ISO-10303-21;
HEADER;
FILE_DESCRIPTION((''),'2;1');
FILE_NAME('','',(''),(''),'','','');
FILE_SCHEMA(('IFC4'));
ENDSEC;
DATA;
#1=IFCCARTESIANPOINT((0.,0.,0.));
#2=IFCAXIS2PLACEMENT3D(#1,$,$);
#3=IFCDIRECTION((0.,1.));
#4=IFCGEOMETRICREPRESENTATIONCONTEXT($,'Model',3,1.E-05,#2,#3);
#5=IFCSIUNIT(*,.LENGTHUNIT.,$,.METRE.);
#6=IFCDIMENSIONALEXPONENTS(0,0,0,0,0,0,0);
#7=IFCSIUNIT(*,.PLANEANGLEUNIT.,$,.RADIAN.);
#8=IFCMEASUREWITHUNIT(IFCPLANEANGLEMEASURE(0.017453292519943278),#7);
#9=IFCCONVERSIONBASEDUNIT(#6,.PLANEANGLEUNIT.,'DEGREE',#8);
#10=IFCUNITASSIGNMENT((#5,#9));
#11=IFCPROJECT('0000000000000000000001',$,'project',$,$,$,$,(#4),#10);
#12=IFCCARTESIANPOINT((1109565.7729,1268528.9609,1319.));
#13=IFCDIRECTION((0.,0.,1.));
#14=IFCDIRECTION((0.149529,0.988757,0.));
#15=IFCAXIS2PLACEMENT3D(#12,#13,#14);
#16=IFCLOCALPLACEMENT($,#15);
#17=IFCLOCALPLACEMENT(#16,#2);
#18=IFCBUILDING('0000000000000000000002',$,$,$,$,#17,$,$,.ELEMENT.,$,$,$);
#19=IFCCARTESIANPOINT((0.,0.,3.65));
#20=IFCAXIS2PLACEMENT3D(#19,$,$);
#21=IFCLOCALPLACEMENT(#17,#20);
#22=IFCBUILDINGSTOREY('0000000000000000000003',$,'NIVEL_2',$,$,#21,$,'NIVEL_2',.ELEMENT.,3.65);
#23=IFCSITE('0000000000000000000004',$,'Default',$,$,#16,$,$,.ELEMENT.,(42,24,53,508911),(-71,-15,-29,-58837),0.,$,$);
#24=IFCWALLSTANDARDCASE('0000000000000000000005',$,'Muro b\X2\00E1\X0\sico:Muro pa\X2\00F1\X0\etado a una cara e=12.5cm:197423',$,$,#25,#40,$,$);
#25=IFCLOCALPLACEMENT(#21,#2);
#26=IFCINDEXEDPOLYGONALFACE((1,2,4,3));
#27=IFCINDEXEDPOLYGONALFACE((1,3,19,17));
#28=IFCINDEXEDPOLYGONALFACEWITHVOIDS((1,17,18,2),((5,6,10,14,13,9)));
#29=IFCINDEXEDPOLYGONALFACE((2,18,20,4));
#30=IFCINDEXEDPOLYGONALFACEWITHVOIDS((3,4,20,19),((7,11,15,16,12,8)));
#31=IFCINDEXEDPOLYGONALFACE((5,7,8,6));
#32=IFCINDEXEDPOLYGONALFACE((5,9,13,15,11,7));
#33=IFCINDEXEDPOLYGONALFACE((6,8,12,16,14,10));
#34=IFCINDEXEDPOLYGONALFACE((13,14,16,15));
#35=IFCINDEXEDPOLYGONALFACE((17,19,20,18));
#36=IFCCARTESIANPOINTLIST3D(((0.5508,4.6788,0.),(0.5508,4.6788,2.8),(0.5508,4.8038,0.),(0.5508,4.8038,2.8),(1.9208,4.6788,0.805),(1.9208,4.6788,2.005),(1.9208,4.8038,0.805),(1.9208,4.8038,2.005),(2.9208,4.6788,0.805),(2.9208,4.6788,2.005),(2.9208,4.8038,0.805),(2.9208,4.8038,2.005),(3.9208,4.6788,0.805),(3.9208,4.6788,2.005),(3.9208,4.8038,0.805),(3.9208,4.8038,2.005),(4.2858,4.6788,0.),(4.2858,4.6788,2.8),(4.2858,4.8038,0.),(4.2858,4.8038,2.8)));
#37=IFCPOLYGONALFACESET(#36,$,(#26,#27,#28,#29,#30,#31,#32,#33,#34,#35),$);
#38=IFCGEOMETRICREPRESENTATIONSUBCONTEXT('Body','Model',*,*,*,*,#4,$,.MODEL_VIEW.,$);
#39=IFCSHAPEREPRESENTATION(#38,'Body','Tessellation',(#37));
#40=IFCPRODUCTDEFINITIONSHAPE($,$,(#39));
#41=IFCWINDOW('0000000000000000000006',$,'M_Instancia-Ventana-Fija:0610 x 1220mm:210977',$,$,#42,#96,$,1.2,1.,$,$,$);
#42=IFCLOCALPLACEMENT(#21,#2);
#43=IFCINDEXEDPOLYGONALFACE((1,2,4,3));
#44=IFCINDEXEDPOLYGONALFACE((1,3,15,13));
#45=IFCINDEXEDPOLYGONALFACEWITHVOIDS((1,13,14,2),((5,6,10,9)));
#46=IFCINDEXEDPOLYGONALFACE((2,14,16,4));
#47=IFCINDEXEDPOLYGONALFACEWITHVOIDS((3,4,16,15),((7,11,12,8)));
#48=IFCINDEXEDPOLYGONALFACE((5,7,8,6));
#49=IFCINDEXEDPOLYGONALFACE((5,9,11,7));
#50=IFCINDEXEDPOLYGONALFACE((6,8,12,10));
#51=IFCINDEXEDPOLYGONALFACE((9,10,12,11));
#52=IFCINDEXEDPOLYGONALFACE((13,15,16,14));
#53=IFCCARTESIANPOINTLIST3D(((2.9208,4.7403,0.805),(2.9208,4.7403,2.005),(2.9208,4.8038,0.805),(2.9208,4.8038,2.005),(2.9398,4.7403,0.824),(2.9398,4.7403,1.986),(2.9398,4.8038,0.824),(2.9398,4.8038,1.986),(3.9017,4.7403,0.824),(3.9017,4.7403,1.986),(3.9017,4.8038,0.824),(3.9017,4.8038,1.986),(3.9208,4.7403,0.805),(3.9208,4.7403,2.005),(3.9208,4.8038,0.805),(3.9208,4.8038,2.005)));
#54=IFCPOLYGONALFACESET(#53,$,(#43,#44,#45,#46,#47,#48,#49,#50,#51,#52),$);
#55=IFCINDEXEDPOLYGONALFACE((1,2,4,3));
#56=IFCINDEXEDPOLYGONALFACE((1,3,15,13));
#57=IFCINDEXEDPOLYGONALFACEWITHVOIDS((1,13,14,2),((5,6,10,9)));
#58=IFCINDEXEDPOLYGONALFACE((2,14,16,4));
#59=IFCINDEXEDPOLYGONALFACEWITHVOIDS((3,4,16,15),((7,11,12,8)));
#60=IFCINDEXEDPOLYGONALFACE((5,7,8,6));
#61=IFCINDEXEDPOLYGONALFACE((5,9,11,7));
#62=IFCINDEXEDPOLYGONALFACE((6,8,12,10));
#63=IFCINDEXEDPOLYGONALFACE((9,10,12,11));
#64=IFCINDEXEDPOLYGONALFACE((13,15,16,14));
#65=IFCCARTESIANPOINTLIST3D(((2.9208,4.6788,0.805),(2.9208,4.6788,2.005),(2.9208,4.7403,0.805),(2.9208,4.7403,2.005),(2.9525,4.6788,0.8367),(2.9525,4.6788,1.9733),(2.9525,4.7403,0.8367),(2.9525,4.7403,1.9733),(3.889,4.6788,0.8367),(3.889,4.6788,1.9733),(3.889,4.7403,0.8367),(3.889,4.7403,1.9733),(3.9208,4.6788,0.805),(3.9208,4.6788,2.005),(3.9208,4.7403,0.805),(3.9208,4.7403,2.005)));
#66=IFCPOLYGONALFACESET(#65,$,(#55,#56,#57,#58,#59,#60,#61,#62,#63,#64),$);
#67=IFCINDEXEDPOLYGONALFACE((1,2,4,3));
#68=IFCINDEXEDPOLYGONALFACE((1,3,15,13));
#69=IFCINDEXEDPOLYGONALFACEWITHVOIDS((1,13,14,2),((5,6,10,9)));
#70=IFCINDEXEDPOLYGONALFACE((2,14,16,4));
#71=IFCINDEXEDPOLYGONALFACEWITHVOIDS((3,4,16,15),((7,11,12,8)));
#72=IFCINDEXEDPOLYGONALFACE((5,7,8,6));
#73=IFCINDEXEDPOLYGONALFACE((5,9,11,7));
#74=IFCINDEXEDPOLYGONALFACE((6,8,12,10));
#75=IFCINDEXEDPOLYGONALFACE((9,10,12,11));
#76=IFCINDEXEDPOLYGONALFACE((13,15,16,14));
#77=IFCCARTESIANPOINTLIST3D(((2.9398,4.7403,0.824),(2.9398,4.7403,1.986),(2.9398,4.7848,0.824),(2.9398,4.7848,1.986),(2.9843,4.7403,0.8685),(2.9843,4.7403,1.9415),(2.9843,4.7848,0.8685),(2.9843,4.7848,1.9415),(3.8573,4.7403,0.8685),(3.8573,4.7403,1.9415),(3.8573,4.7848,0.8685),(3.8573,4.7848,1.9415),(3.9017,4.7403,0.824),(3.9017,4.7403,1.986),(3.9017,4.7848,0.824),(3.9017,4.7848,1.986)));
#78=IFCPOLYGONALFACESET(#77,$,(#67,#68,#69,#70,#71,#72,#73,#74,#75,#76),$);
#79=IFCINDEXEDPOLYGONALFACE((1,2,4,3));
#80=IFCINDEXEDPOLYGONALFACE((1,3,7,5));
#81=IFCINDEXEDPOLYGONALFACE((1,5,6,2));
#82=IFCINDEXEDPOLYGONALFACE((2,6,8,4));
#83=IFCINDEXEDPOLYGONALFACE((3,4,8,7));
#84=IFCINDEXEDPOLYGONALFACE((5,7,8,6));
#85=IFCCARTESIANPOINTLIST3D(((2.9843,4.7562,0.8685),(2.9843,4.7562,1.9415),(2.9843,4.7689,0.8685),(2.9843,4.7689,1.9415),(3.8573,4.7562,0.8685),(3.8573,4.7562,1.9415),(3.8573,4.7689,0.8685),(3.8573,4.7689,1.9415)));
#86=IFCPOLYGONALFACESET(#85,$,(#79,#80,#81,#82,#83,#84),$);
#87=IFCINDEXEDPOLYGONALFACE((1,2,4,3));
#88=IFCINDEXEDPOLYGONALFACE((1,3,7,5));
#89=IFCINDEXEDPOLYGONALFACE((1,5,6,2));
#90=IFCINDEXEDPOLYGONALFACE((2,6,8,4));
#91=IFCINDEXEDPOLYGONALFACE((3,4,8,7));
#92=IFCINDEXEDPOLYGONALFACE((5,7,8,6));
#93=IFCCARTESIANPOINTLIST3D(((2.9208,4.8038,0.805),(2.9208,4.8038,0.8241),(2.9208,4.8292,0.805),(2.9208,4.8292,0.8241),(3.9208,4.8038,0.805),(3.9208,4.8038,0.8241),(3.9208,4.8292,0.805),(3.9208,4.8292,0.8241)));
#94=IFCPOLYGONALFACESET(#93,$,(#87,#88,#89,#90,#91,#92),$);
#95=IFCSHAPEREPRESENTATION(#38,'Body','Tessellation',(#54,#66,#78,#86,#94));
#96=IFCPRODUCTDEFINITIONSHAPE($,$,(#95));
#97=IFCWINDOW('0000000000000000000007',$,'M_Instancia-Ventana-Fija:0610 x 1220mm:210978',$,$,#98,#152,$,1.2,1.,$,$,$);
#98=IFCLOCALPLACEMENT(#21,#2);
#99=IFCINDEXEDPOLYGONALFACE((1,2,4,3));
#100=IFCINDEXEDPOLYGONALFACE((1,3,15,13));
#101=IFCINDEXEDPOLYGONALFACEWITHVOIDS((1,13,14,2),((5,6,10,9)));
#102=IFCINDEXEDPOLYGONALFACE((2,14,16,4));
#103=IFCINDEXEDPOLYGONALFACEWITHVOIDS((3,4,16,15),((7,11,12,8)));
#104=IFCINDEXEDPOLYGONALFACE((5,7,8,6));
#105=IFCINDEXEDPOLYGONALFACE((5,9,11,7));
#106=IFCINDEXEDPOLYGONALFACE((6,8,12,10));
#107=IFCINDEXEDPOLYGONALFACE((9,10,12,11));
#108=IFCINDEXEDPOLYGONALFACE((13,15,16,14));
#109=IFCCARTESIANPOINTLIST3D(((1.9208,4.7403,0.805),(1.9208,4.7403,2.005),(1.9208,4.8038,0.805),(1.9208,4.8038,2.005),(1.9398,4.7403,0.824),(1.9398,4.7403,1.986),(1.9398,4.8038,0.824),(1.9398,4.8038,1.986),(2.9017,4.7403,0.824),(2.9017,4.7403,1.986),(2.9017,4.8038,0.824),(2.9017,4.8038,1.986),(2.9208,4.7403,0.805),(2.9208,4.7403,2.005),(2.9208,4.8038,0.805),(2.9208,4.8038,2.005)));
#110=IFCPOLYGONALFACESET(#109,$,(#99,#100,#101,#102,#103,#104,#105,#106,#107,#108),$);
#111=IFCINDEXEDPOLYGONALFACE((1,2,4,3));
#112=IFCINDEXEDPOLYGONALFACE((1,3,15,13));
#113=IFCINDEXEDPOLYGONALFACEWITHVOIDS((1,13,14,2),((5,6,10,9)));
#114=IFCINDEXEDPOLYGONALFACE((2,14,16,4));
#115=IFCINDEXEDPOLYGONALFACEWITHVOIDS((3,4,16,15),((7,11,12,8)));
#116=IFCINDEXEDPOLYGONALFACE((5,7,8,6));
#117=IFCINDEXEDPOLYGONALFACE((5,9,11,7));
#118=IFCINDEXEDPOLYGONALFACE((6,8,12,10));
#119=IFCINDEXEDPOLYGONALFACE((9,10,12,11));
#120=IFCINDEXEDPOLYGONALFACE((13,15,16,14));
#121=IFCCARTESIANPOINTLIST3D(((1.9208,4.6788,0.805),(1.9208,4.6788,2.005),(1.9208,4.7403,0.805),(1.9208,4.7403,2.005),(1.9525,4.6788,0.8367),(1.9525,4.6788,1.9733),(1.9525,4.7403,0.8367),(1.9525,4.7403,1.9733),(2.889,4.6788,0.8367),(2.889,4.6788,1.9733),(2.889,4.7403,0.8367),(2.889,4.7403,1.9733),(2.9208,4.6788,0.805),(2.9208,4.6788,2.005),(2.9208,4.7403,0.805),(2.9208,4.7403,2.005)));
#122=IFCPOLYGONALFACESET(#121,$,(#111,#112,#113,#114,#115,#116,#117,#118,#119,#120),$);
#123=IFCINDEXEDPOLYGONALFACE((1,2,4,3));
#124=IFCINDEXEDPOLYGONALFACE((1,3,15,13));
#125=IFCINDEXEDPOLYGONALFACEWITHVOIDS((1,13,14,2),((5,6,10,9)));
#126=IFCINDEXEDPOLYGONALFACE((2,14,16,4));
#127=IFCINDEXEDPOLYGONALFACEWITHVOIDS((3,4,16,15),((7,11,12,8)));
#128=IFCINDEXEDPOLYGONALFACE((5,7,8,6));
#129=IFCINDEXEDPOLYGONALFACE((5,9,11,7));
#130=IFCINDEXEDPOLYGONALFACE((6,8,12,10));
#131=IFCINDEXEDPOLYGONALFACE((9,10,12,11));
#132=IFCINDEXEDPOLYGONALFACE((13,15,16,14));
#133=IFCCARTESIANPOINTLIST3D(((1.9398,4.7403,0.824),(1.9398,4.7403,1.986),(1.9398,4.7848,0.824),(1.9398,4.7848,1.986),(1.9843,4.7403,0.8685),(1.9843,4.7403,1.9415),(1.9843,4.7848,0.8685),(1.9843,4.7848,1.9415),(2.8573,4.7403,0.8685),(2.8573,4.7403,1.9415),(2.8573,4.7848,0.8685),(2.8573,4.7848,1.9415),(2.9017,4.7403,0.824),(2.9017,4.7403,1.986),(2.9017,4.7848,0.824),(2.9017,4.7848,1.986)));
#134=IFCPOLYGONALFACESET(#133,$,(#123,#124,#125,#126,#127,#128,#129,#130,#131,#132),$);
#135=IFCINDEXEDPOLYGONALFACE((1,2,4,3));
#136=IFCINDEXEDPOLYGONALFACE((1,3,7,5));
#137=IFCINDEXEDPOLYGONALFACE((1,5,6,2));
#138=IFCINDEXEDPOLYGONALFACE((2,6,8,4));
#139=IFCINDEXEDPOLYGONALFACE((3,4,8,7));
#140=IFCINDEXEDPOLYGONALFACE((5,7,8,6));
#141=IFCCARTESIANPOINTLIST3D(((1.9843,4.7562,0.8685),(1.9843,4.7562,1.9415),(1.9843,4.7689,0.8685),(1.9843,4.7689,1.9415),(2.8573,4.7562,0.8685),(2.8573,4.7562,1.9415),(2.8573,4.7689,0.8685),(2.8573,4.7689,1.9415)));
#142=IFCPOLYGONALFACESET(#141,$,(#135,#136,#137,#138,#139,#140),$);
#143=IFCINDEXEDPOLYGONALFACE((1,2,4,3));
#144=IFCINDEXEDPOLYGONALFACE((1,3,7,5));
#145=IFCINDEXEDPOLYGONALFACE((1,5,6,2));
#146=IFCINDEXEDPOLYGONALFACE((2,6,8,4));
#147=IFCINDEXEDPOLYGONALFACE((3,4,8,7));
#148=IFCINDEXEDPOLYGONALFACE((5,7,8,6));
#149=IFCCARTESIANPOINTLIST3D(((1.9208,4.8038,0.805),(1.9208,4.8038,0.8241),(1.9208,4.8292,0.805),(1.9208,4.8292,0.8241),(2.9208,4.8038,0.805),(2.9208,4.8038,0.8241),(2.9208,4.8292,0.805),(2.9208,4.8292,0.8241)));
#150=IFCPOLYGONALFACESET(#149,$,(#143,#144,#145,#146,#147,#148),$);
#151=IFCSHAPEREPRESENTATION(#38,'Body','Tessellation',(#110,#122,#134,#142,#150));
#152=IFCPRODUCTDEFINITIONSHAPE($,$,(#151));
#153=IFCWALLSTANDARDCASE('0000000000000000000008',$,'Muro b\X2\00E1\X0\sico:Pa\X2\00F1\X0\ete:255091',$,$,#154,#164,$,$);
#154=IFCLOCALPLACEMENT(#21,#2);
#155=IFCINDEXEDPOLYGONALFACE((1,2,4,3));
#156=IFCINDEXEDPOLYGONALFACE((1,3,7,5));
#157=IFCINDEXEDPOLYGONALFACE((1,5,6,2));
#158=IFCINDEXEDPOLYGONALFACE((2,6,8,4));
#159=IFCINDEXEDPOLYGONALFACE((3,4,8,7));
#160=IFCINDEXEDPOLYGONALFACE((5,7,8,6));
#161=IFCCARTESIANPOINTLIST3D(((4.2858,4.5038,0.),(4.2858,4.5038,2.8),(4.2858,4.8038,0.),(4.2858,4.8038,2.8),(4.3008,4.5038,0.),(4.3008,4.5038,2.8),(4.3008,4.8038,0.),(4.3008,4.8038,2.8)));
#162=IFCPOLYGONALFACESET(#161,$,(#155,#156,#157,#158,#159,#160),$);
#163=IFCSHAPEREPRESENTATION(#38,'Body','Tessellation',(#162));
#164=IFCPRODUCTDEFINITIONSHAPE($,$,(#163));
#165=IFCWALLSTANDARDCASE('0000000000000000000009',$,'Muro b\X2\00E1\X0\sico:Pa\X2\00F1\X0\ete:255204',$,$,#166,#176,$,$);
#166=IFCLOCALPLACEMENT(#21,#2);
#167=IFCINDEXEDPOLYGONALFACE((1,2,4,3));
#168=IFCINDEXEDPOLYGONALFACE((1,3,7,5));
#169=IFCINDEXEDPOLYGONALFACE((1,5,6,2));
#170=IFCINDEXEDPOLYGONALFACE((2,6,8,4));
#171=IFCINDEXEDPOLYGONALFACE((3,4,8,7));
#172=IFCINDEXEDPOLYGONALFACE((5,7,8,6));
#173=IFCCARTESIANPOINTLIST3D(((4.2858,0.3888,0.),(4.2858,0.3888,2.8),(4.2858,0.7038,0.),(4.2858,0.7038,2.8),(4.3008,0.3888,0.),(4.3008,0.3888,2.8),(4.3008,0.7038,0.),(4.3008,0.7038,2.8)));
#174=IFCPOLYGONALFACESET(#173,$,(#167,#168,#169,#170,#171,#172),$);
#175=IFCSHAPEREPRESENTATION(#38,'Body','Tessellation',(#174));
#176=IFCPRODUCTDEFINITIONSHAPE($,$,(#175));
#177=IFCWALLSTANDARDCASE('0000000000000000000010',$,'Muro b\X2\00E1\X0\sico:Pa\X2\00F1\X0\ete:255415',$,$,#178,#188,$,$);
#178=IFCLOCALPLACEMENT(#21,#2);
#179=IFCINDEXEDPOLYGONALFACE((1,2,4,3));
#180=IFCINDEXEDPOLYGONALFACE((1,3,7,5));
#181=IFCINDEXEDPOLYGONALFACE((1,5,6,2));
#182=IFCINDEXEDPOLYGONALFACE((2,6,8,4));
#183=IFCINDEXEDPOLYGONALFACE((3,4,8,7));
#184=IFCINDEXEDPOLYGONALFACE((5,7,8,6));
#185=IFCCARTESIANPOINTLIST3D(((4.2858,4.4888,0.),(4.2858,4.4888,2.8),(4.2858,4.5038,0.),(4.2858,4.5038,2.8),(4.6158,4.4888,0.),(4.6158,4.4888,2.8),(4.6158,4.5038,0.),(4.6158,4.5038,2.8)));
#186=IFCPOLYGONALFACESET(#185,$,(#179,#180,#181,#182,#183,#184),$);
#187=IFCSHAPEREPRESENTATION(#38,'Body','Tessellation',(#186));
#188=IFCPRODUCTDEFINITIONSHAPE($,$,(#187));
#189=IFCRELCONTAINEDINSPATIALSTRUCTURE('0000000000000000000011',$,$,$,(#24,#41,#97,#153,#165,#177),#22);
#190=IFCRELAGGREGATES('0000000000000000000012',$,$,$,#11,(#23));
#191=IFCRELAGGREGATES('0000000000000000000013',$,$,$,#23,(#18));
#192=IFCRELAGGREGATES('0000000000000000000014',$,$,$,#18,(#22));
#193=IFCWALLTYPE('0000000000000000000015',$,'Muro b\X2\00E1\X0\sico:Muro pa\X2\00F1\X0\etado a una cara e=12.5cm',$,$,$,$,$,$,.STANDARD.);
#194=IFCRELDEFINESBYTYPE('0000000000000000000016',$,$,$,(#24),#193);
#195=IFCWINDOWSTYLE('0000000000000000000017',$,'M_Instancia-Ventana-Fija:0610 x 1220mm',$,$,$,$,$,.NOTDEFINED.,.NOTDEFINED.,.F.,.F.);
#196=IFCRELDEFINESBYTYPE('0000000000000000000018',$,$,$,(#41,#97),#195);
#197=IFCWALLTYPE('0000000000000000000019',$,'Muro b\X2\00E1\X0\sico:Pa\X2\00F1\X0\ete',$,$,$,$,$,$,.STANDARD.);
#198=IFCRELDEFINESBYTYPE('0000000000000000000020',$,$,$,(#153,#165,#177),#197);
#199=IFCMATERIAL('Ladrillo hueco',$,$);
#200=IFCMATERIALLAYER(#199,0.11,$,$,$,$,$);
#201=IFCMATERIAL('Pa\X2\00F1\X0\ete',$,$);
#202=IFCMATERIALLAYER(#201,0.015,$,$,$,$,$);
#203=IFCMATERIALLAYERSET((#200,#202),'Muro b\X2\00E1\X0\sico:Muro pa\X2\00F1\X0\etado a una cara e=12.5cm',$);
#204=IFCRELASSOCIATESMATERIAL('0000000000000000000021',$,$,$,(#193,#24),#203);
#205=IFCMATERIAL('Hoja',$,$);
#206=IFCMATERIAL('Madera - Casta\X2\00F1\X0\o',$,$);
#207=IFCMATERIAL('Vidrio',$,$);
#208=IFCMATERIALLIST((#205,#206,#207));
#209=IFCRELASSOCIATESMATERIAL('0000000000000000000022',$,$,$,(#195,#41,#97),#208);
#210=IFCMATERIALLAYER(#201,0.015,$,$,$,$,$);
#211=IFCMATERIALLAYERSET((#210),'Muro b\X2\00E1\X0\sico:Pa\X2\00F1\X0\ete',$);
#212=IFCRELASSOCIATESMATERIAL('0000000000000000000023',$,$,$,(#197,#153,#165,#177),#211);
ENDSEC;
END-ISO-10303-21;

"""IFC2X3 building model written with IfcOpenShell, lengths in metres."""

from ifc_helpers import new_model, entity, si_unit, converted_unit, direction, frame, frame_2d, origin, origin_2d_with_axis, place, context, subcontext, project, spatial, polyline, rectangle, outline, extrude, source, transform, mapped, material, material_list, layer, layer_set, layer_usage, type_object, type_shapes, element, fill, save


model = new_model("IFC2X3")

# Units and contexts
model_context = context("Model", 3, precision=1e-05, world=origin(), true_north=direction((0.0, 1.0)))
body_context = subcontext(model_context, "Body", "Model", "MODEL_VIEW")
ifc_project = project(units=[si_unit("LENGTHUNIT", "METRE"), converted_unit("PLANEANGLEUNIT", "DEGREE", entity("IfcPlaneAngleMeasure", 0.017453292519943278), si_unit("PLANEANGLEUNIT", "RADIAN"), dimensions=[0, 0, 0, 0, 0, 0, 0])], contexts=[model_context])

# Site, building, storey
site_placement = place(None, frame((1109565.7729, 1268528.9609, 1319.0), z_axis=(0.0, 0.0, 1.0), x_axis=(0.149529, 0.988757, 0.0)))
site = spatial("IfcSite", under=ifc_project, at=site_placement, Name="Default", CompositionType="ELEMENT", RefLatitude=(42, 24, 53, 508911), RefLongitude=(-71, -15, -29, -58837), RefElevation=0.0)
building_placement = place(site_placement, origin())
building = spatial("IfcBuilding", under=site, at=building_placement, CompositionType="ELEMENT")
storey_placement = place(building_placement, frame((0.0, 0.0, 3.65)))
storey = spatial("IfcBuildingStorey", under=building, at=storey_placement, Name="NIVEL_2", LongName="NIVEL_2", CompositionType="ELEMENT", Elevation=3.65)

# Shared definitions
ifc_material_1 = material(Name="Pañete")
ifc_material_2 = material(Name="Ladrillo hueco")

# Shared definitions
ifc_layer_1 = layer(ifc_material_2, 0.11)
ifc_layer_2 = layer(ifc_material_1, 0.015)
ifc_layer_set_1 = layer_set([ifc_layer_1, ifc_layer_2], Name="Muro básico:Muro pañetado a una cara e=12.5cm")
wall_type_1 = type_object("IfcWallType", Name="Muro básico:Muro pañetado a una cara e=12.5cm", PredefinedType="STANDARD", material=ifc_layer_set_1)

# Shared definitions
ifc_material_3 = material(Name="Hoja")
ifc_material_4 = material(Name="Madera - Castaño")
ifc_material_5 = material(Name="Vidrio")
ifc_material_list = material_list([ifc_material_3, ifc_material_4, ifc_material_5])

# Wall, openings, windows
ifc_layer_usage_1 = layer_usage(ifc_layer_set_1, "AXIS2", "POSITIVE", -0.0625)
wall_1_placement = place(storey_placement, frame((4.2858, 4.7413, 0.0), z_axis=(0.0, 0.0, 1.0), x_axis=(-1.0, 0.0, 0.0)))
wall_1 = element("IfcWallStandardCase", 1, at=wall_1_placement, inside=storey, type_object=wall_type_1, material=ifc_layer_usage_1, Name="Muro básico:Muro pañetado a una cara e=12.5cm:197423", context=body_context, shape_type="SweptSolid", body=[
    extrude(rectangle(XDim=3.735, YDim=0.125, at=frame_2d((1.8675, 0.0), x_axis=(-1.0, 0.0))), origin(), (0.0, 0.0, 1.0), 2.8),
])
opening_1_placement = place(wall_1_placement, frame((2.365, 0.0625, 0.805)))
opening_1 = element("IfcOpeningElement", 2, at=opening_1_placement, cuts=wall_1, ObjectType="Opening", context=body_context, shape_type="SweptSolid", body=[
    extrude(rectangle(XDim=1.2, YDim=1.0, at=frame_2d((0.6, 0.5), x_axis=(-1.0, 0.0))), frame((0.0, 0.0, 0.0), z_axis=(0.0, -1.0, 0.0), x_axis=(0.0, 0.0, 1.0)), (0.0, 0.0, 1.0), 0.125),
])
opening_2_placement = place(wall_1_placement, frame((1.365, 0.0625, 0.805)))
opening_2 = element("IfcOpeningElement", 3, at=opening_2_placement, cuts=wall_1, ObjectType="Opening", context=body_context, shape_type="SweptSolid", body=[
    extrude(rectangle(XDim=1.2, YDim=1.0, at=frame_2d((0.6, 0.5), x_axis=(-1.0, 0.0))), frame((0.0, 0.0, 0.0), z_axis=(0.0, -1.0, 0.0), x_axis=(0.0, 0.0, 1.0)), (0.0, 0.0, 1.0), 0.125),
])
window_style_1 = type_object("IfcWindowStyle", Name="M_Instancia-Ventana-Fija:0610 x 1220mm", ConstructionType="NOTDEFINED", OperationType="NOTDEFINED", ParameterTakesPrecedence=False, Sizeable=False, material=ifc_material_list)
shared_shape_1 = source(origin(), body_context, "Body", "SweptSolid", [
    extrude(outline(polyline([(-0.6, -0.5), (0.6, -0.5), (0.6, 0.5), (-0.6, 0.5), (-0.6, -0.5)]), holes=[polyline([(-0.5809, -0.4809), (-0.5809, 0.481), (0.581, 0.481), (0.581, -0.4809), (-0.5809, -0.4809)])]), frame((0.5, 0.0616, 0.6), z_axis=(0.0, 1.0, 0.0), x_axis=(0.0, 0.0, -1.0)), (0.0, 0.0, 1.0), 0.0635),
    extrude(outline(polyline([(-0.5, -0.6), (0.5, -0.6), (0.5, 0.6), (-0.5, 0.6), (-0.5, -0.6)]), holes=[polyline([(-0.4683, -0.5682), (-0.4683, 0.5683), (0.4682, 0.5683), (0.4682, -0.5682), (-0.4683, -0.5682)])]), frame((0.5, 0.0, 0.6), z_axis=(0.0, 1.0, 0.0), x_axis=(1.0, 0.0, 0.0)), (0.0, 0.0, 1.0), 0.0616),
    extrude(outline(polyline([(-0.4809, -0.581), (0.4809, -0.581), (0.4809, 0.581), (-0.4809, 0.581), (-0.4809, -0.581)]), holes=[polyline([(-0.4365, -0.5365), (-0.4365, 0.5365), (0.4365, 0.5365), (0.4365, -0.5365), (-0.4365, -0.5365)])]), frame((0.5, 0.0616, 0.6), z_axis=(0.0, 1.0, 0.0), x_axis=(1.0, 0.0, 0.0)), (0.0, 0.0, 1.0), 0.0444),
    extrude(rectangle(XDim=0.0127, YDim=0.873, at=origin_2d_with_axis()), frame((0.5, 0.0838, 0.0635), z_axis=(0.0, 0.0, 1.0), x_axis=(0.0, 1.0, 0.0)), (0.0, 0.0, 1.0), 1.073),
    extrude(rectangle(XDim=0.0254, YDim=1.0, at=origin_2d_with_axis()), frame((0.5, 0.1377, 0.0), z_axis=(0.0, 0.0, 1.0), x_axis=(0.0, -1.0, 0.0)), (0.0, 0.0, 1.0), 0.019),
])
type_shapes(window_style_1, [shared_shape_1])
window_1_placement = place(opening_2_placement, frame((0.0, 0.0, 0.0), z_axis=(0.0, 0.0, 1.0), x_axis=(-1.0, 0.0, 0.0)))
window_1 = element("IfcWindow", 4, at=window_1_placement, inside=storey, type_object=window_style_1, material=ifc_material_list, Name="M_Instancia-Ventana-Fija:0610 x 1220mm:210977", OverallHeight=1.2, OverallWidth=1.0, context=body_context, shape_type="MappedRepresentation", body=[
    mapped(shared_shape_1, transform((0.0, 0.0, 0.0), scale=1.0)),
])
fill(opening_2, window_1)
window_2_placement = place(opening_1_placement, frame((0.0, 0.0, 0.0), z_axis=(0.0, 0.0, 1.0), x_axis=(-1.0, 0.0, 0.0)))
window_2 = element("IfcWindow", 5, at=window_2_placement, inside=storey, type_object=window_style_1, material=ifc_material_list, Name="M_Instancia-Ventana-Fija:0610 x 1220mm:210978", OverallHeight=1.2, OverallWidth=1.0, context=body_context, shape_type="MappedRepresentation", body=[
    mapped(shared_shape_1, transform((0.0, 0.0, 0.0), scale=1.0)),
])
fill(opening_1, window_2)

# Walls
ifc_layer_3 = layer(ifc_material_1, 0.015)
ifc_layer_set_2 = layer_set([ifc_layer_3], Name="Muro básico:Pañete")
ifc_layer_usage_2 = layer_usage(ifc_layer_set_2, "AXIS2", "POSITIVE", -0.0075)
wall_type_2 = type_object("IfcWallType", Name="Muro básico:Pañete", PredefinedType="STANDARD", material=ifc_layer_set_2)
wall_2_placement = place(storey_placement, frame((4.2933, 4.8038, 0.0), z_axis=(0.0, 0.0, 1.0), x_axis=(0.0, -1.0, 0.0)))
element("IfcWallStandardCase", 6, at=wall_2_placement, inside=storey, type_object=wall_type_2, material=ifc_layer_usage_2, Name="Muro básico:Pañete:255091", context=body_context, shape_type="SweptSolid", body=[
    extrude(rectangle(XDim=0.3, YDim=0.015, at=frame_2d((0.15, 0.0), x_axis=(-1.0, 0.0))), origin(), (0.0, 0.0, 1.0), 2.8),
])
ifc_layer_usage_3 = layer_usage(ifc_layer_set_2, "AXIS2", "POSITIVE", -0.0075)
wall_3_placement = place(storey_placement, frame((4.2933, 0.7038, 0.0), z_axis=(0.0, 0.0, 1.0), x_axis=(0.0, -1.0, 0.0)))
element("IfcWallStandardCase", 7, at=wall_3_placement, inside=storey, type_object=wall_type_2, material=ifc_layer_usage_3, Name="Muro básico:Pañete:255204", context=body_context, shape_type="SweptSolid", body=[
    extrude(rectangle(XDim=0.315, YDim=0.015, at=frame_2d((0.1575, 0.0), x_axis=(-1.0, 0.0))), origin(), (0.0, 0.0, 1.0), 2.8),
])
ifc_layer_usage_4 = layer_usage(ifc_layer_set_2, "AXIS2", "POSITIVE", -0.0075)
wall_4_placement = place(storey_placement, frame((4.2858, 4.4963, 0.0)))
element("IfcWallStandardCase", 8, at=wall_4_placement, inside=storey, type_object=wall_type_2, material=ifc_layer_usage_4, Name="Muro básico:Pañete:255415", context=body_context, shape_type="SweptSolid", body=[
    extrude(rectangle(XDim=0.33, YDim=0.015, at=frame_2d((0.165, 0.0), x_axis=(-1.0, 0.0))), origin(), (0.0, 0.0, 1.0), 2.8),
])

save(model, "model.ifc")
